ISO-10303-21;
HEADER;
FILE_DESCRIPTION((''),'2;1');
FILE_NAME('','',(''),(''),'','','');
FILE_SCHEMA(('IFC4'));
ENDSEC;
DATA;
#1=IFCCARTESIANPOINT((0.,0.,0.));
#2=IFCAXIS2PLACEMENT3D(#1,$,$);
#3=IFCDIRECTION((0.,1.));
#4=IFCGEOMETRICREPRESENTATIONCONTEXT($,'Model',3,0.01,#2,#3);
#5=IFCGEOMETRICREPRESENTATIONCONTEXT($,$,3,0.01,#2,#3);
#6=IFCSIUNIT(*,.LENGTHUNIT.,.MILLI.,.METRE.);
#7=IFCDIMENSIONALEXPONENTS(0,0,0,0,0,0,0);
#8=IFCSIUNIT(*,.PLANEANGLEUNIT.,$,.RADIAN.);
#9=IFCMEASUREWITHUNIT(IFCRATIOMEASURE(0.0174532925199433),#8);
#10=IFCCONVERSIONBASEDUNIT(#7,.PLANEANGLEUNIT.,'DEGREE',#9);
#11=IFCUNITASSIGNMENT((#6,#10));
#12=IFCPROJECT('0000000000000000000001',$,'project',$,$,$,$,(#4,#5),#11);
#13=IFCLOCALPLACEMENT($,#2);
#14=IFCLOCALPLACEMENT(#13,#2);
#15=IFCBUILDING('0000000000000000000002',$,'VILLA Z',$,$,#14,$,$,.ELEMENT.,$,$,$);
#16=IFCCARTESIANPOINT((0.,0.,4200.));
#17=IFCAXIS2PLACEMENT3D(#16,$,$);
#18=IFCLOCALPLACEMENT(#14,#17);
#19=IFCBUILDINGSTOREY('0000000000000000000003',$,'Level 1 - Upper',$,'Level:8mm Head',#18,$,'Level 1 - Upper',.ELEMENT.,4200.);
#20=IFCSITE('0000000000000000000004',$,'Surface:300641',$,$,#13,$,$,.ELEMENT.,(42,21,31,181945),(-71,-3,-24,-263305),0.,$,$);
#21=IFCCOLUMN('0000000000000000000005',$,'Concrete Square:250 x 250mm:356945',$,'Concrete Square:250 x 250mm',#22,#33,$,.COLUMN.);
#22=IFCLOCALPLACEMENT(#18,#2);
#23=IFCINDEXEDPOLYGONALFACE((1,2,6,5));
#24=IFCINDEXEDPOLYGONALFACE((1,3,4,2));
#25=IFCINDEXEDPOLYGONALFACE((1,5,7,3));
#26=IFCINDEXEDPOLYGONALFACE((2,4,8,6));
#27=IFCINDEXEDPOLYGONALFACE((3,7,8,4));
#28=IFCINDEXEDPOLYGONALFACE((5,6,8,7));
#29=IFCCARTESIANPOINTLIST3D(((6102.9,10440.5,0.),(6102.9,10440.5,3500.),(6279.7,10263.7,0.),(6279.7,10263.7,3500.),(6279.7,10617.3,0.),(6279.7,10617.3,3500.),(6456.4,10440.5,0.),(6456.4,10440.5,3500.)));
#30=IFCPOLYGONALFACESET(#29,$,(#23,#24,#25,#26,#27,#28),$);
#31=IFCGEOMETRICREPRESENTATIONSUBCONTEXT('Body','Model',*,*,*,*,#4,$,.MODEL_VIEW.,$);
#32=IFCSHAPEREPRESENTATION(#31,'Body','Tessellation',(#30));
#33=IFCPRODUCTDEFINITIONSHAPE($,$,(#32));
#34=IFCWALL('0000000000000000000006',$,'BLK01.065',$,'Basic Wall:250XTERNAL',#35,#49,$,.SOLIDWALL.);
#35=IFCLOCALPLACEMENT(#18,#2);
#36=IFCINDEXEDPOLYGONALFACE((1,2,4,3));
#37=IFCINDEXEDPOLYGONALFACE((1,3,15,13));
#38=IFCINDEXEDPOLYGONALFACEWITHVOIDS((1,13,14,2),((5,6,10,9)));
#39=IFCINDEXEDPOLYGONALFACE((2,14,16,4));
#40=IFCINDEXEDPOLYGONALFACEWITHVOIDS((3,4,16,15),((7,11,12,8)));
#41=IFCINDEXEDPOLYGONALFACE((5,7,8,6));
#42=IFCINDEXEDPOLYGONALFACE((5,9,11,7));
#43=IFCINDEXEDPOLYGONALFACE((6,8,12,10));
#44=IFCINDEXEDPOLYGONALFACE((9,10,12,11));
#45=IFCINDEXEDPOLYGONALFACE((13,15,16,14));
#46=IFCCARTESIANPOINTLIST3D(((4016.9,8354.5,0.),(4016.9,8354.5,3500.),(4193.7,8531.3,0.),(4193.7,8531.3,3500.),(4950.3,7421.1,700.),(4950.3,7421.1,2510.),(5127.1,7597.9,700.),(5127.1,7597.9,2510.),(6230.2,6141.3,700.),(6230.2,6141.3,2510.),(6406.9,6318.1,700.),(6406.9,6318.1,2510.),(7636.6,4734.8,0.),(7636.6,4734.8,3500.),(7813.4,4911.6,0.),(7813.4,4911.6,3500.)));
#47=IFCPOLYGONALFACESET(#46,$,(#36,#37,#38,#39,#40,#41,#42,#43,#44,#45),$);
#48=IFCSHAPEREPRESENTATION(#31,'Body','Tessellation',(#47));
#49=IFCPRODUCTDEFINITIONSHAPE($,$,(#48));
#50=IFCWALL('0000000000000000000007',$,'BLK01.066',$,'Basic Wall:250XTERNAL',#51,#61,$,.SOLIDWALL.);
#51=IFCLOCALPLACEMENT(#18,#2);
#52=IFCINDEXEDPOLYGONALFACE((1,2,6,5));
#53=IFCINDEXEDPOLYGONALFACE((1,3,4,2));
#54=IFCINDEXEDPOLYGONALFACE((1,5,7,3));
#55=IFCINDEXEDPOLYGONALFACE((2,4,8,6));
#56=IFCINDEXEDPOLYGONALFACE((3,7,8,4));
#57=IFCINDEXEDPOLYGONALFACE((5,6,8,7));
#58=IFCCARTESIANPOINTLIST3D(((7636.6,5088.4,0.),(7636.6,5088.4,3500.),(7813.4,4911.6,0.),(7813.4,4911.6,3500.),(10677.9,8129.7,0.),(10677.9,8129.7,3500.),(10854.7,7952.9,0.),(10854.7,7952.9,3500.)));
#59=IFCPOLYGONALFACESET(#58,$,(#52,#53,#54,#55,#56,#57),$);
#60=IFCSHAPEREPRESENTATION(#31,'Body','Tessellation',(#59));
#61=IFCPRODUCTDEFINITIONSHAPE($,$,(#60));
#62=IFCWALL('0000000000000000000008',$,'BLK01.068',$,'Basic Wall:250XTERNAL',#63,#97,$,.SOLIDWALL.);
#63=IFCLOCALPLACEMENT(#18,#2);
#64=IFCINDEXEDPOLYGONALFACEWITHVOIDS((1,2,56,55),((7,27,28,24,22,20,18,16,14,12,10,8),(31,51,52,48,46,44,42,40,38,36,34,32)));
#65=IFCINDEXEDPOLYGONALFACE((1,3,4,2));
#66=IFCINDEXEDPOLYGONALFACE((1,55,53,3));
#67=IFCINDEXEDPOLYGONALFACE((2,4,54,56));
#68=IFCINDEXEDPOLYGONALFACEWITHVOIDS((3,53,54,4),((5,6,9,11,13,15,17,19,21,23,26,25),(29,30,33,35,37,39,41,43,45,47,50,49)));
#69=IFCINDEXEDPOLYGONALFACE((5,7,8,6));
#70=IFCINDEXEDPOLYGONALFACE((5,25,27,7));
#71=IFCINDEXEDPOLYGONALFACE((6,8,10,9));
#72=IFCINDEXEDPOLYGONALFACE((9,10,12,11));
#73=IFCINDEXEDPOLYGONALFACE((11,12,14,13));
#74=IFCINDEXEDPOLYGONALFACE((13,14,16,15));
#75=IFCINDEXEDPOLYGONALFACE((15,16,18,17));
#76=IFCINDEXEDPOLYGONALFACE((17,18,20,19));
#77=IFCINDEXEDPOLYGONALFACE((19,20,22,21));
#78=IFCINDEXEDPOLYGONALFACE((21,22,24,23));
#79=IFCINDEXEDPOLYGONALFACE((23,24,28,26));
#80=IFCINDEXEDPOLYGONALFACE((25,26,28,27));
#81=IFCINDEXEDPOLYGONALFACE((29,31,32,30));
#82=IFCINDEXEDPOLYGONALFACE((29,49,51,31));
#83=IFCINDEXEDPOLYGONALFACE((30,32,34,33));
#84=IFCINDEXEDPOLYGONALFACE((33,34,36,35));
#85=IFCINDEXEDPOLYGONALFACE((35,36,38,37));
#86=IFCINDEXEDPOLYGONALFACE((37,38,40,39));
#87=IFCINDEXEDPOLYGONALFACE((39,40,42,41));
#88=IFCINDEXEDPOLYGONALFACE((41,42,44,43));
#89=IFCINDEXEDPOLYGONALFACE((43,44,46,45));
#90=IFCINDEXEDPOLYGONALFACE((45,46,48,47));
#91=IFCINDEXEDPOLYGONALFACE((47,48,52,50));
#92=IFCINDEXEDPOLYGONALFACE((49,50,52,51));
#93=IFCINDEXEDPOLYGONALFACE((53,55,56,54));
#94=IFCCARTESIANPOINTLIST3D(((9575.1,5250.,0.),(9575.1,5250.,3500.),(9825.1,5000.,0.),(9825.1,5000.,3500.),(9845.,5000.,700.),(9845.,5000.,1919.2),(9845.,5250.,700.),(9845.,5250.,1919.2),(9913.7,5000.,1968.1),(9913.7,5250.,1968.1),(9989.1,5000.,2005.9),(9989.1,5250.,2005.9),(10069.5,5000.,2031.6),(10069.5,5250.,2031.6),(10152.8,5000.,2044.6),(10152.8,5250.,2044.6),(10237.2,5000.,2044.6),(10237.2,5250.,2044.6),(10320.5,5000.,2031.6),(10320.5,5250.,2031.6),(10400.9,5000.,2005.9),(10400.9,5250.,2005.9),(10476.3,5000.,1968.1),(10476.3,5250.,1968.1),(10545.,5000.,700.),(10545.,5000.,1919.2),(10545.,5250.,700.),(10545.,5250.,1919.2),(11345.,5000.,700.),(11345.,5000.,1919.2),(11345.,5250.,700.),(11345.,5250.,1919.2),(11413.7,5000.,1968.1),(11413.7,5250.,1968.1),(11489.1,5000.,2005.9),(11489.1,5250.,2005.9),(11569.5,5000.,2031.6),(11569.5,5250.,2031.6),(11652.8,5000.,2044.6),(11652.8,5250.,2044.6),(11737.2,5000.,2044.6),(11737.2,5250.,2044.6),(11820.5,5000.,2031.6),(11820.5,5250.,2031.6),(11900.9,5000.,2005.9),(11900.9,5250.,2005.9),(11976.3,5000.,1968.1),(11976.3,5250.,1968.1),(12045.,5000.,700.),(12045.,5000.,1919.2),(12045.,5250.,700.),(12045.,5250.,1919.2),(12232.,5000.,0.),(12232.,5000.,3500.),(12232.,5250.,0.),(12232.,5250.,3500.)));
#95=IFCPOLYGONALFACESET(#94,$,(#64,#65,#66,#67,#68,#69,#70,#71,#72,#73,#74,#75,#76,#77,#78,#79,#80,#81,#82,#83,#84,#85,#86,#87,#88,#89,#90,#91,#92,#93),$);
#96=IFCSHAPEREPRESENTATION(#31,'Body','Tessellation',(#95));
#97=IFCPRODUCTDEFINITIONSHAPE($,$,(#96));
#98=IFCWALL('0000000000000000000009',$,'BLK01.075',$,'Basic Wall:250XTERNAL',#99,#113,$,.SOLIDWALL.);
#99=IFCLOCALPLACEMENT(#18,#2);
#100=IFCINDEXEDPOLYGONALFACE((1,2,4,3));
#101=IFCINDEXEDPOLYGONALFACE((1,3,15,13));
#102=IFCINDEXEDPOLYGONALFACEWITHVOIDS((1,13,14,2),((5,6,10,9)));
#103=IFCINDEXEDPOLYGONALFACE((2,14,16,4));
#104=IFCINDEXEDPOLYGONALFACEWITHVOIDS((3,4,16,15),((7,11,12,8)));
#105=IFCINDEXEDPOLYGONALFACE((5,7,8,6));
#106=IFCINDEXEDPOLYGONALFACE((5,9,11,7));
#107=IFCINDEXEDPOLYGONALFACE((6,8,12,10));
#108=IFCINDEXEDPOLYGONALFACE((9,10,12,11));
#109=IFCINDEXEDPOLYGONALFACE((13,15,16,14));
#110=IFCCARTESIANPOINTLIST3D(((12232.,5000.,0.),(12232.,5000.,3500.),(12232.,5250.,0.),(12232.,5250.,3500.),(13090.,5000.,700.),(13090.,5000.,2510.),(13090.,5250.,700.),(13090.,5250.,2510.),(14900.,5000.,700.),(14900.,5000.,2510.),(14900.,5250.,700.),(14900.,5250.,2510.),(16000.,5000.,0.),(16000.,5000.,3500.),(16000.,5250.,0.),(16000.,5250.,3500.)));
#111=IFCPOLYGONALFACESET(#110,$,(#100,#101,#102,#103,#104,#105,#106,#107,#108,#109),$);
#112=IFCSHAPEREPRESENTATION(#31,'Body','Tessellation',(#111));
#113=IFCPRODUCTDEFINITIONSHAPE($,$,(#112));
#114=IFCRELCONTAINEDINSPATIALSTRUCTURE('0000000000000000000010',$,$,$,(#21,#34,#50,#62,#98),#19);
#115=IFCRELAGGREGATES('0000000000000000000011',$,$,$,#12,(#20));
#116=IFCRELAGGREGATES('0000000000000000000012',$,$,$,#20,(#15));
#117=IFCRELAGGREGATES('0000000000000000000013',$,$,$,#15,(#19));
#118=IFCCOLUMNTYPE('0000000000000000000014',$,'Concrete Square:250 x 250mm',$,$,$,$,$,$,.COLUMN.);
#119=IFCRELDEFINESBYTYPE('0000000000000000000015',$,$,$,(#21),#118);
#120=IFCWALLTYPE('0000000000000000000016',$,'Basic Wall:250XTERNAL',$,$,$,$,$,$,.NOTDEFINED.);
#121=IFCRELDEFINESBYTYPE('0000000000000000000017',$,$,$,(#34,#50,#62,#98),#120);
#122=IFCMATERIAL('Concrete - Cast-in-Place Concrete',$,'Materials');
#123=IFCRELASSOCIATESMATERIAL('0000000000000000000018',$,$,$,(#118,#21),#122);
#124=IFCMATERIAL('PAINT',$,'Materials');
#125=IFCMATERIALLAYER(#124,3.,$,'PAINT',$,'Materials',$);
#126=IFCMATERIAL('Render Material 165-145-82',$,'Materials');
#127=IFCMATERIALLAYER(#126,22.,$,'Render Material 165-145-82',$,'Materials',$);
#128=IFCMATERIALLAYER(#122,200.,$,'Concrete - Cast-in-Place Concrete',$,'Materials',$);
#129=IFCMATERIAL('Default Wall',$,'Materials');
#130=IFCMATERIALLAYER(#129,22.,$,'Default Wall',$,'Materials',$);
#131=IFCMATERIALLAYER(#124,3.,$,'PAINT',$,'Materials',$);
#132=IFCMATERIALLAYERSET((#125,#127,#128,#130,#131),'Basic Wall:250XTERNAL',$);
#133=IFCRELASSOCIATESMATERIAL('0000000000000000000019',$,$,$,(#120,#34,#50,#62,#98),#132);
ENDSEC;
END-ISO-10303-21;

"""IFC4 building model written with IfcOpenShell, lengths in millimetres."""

from ifc_helpers import new_model, entity, si_unit, converted_unit, direction, frame, frame_2d, origin, origin_2d_with_axis, place, context, subcontext, project, spatial, polyline, circle_curve, parameter, trimmed, segment, composite_curve, rectangle, outline, extrude, clip, halfspace, source, transform, mapped, material, layer, layer_set, layer_usage, material_profile, profile_set, profile_usage, type_object, type_shapes, element, save


model = new_model("IFC4")

# Units and contexts
model_context = context("Model", 3, precision=0.01, world=origin(), true_north=direction((0.0, 1.0)))
context_of_model = context(None, 3, precision=0.01, world=origin(), true_north=direction((0.0, 1.0)))
body_context = subcontext(model_context, "Body", "Model", "MODEL_VIEW")
ifc_project = project(units=[si_unit("LENGTHUNIT", "METRE", prefix="MILLI"), converted_unit("PLANEANGLEUNIT", "DEGREE", entity("IfcRatioMeasure", 0.0174532925199433), si_unit("PLANEANGLEUNIT", "RADIAN"), dimensions=[0, 0, 0, 0, 0, 0, 0])], contexts=[model_context, context_of_model])

# Site, building, storey
site_placement = place(None, origin())
site = spatial("IfcSite", under=ifc_project, at=site_placement, Name="Surface:300641", CompositionType="ELEMENT", RefLatitude=(42, 21, 31, 181945), RefLongitude=(-71, -3, -24, -263305), RefElevation=0.0)
building_placement = place(site_placement, origin())
building = spatial("IfcBuilding", under=site, at=building_placement, Name="VILLA Z", CompositionType="ELEMENT")
storey_placement = place(building_placement, frame((0.0, 0.0, 4200.0)))
storey = spatial("IfcBuildingStorey", under=building, at=storey_placement, Name="Level 1 - Upper", ObjectType="Level:8mm Head", LongName="Level 1 - Upper", CompositionType="ELEMENT", Elevation=4200.0)

# Column
ifc_material_1 = material(Name="Concrete - Cast-in-Place Concrete", Category="Materials")
ifc_material_profile_1 = material_profile(ifc_material_1, rectangle(XDim=250.0, YDim=250.0, at=frame_2d((0.0, 0.0), x_axis=(1.0, 0.0))), Name="250 x 250mm")
ifc_profile_set_1 = profile_set([ifc_material_profile_1], Name="250 x 250mm")
ifc_profile_usage_1 = profile_usage(ifc_profile_set_1)
column_type = type_object("IfcColumnType", Name="Concrete Square:250 x 250mm", PredefinedType="COLUMN", material=ifc_profile_set_1)
shared_shape_1 = source(origin(), body_context, "Body", "SweptSolid", [
    extrude(rectangle(XDim=250.0, YDim=250.0, at=origin_2d_with_axis()), frame((6279.7, 10440.5, 4200.0), z_axis=(0.0, 0.0, 1.0), x_axis=(-0.707107, 0.707107, 0.0)), (0.0, 0.0, 1.0), 3500.0),
])
type_shapes(column_type, [shared_shape_1])
column_placement = place(storey_placement, frame((0.0, 0.0, -4200.0)))
element("IfcColumn", 1, at=column_placement, inside=storey, type_object=column_type, material=ifc_profile_usage_1, Name="Concrete Square:250 x 250mm:356945", ObjectType="Concrete Square:250 x 250mm", PredefinedType="COLUMN", context=body_context, shape_type="MappedRepresentation", body=[
    mapped(shared_shape_1, transform((0.0, 0.0, 0.0), scale=1.0)),
])

# Wall, opening
ifc_material_2 = material(Name="PAINT", Category="Materials")
ifc_layer_1 = layer(ifc_material_2, 3.0, Name="PAINT", Category="Materials")
ifc_material_3 = material(Name="Render Material 165-145-82", Category="Materials")
ifc_layer_2 = layer(ifc_material_3, 22.0, Name="Render Material 165-145-82", Category="Materials")
ifc_layer_3 = layer(ifc_material_1, 200.0, Name="Concrete - Cast-in-Place Concrete", Category="Materials")
ifc_material_4 = material(Name="Default Wall", Category="Materials")
ifc_layer_4 = layer(ifc_material_4, 22.0, Name="Default Wall", Category="Materials")
ifc_layer_5 = layer(ifc_material_2, 3.0, Name="PAINT", Category="Materials")
ifc_layer_set_1 = layer_set([ifc_layer_1, ifc_layer_2, ifc_layer_3, ifc_layer_4, ifc_layer_5], Name="Basic Wall:250XTERNAL")
ifc_layer_usage_1 = layer_usage(ifc_layer_set_1, "AXIS2", "NEGATIVE", 125.0)
wall_type_1 = type_object("IfcWallType", Name="Basic Wall:250XTERNAL", PredefinedType="NOTDEFINED", material=ifc_layer_set_1)
wall_1_placement = place(storey_placement, frame((7725.0, 4823.2, 0.0), z_axis=(0.0, 0.0, 1.0), x_axis=(-0.707107, 0.707107, 0.0)))
wall_1 = element("IfcWall", 2, at=wall_1_placement, inside=storey, type_object=wall_type_1, material=ifc_layer_usage_1, Name="BLK01.065", ObjectType="Basic Wall:250XTERNAL", PredefinedType="SOLIDWALL", context=body_context, shape_type="Clipping", body=[
    clip(extrude(rectangle(XDim=5119.0, YDim=250.0, at=frame_2d((2559.5, 0.0), x_axis=(-1.0, 0.0))), origin(), (0.0, 0.0, 1.0), 3500.0), halfspace(origin(), True)),
])
opening_1_placement = place(wall_1_placement, frame((1989.0, -125.0, 700.0)))
element("IfcOpeningElement", 3, at=opening_1_placement, cuts=wall_1, ObjectType="Opening", PredefinedType="OPENING", context=body_context, shape_type="SweptSolid", body=[
    extrude(rectangle(XDim=1810.0, YDim=1810.0, at=frame_2d((905.0, 905.0), x_axis=(-1.0, 0.0))), frame((0.0, 0.0, 0.0), z_axis=(0.0, 1.0, 0.0), x_axis=(0.0, 0.0, 1.0)), (0.0, 0.0, 1.0), 250.0),
])

# Wall
ifc_layer_usage_2 = layer_usage(ifc_layer_set_1, "AXIS2", "NEGATIVE", 125.0)
wall_2_placement = place(storey_placement, frame((7725.0, 5000.0, 0.0), z_axis=(0.0, 0.0, 1.0), x_axis=(0.707107, 0.707107, 0.0)))
element("IfcWall", 4, at=wall_2_placement, inside=storey, type_object=wall_type_1, material=ifc_layer_usage_2, Name="BLK01.066", ObjectType="Basic Wall:250XTERNAL", PredefinedType="SOLIDWALL", context=body_context, shape_type="Clipping", body=[
    clip(extrude(rectangle(XDim=4301.0, YDim=250.0, at=frame_2d((2150.5, 0.0), x_axis=(-1.0, 0.0))), origin(), (0.0, 0.0, 1.0), 3500.0), halfspace(origin(), True)),
])

# Wall, openings
ifc_layer_usage_3 = layer_usage(ifc_layer_set_1, "AXIS2", "NEGATIVE", 125.0)
wall_3_placement = place(storey_placement, frame((9575.1, 5125.0, 0.0)))
wall_3 = element("IfcWall", 5, at=wall_3_placement, inside=storey, type_object=wall_type_1, material=ifc_layer_usage_3, Name="BLK01.068", ObjectType="Basic Wall:250XTERNAL", PredefinedType="SOLIDWALL", context=body_context, shape_type="Clipping", body=[
    clip(extrude(outline(polyline([(2656.9, -125.0), (2656.9, 125.0), (0.0, 125.0), (250.0, -125.0), (2656.9, -125.0)])), origin(), (0.0, 0.0, 1.0), 3500.0), halfspace(origin(), True)),
])
opening_2_placement = place(wall_3_placement, frame((969.9, 125.0, 700.0)))
element("IfcOpeningElement", 6, at=opening_2_placement, cuts=wall_3, ObjectType="Opening", PredefinedType="OPENING", context=body_context, shape_type="SweptSolid", body=[
    extrude(outline(composite_curve([segment(polyline([(0.0, 0.0), (1219.2, 0.0)]), True, "CONTINUOUS"), segment(trimmed(circle_curve(frame_2d((800.4, 350.0), x_axis=(0.0, 1.0)), 545.8), [parameter(230.112671)], [parameter(309.887329)], True, "PARAMETER"), True, "CONTINUOUS"), segment(polyline([(1219.2, 700.0), (0.0, 700.0)]), True, "CONTINUOUS"), segment(polyline([(0.0, 700.0), (0.0, 0.0)]), True, "CONTINUOUS")], self_intersect=False)), frame((0.0, 0.0, 0.0), z_axis=(0.0, -1.0, 0.0), x_axis=(0.0, 0.0, 1.0)), (0.0, 0.0, 1.0), 250.0),
])
opening_3_placement = place(wall_3_placement, frame((2469.9, 125.0, 700.0)))
element("IfcOpeningElement", 7, at=opening_3_placement, cuts=wall_3, ObjectType="Opening", PredefinedType="OPENING", context=body_context, shape_type="SweptSolid", body=[
    extrude(outline(composite_curve([segment(polyline([(0.0, 0.0), (1219.2, 0.0)]), True, "CONTINUOUS"), segment(trimmed(circle_curve(frame_2d((800.4, 350.0), x_axis=(0.0, 1.0)), 545.8), [parameter(230.112671)], [parameter(309.887329)], True, "PARAMETER"), True, "CONTINUOUS"), segment(polyline([(1219.2, 700.0), (0.0, 700.0)]), True, "CONTINUOUS"), segment(polyline([(0.0, 700.0), (0.0, 0.0)]), True, "CONTINUOUS")], self_intersect=False)), frame((0.0, 0.0, 0.0), z_axis=(0.0, -1.0, 0.0), x_axis=(0.0, 0.0, 1.0)), (0.0, 0.0, 1.0), 250.0),
])

# Wall, opening
ifc_layer_usage_4 = layer_usage(ifc_layer_set_1, "AXIS2", "NEGATIVE", 125.0)
wall_4_placement = place(storey_placement, frame((12232.0, 5125.0, 0.0)))
wall_4 = element("IfcWall", 8, at=wall_4_placement, inside=storey, type_object=wall_type_1, material=ifc_layer_usage_4, Name="BLK01.075", ObjectType="Basic Wall:250XTERNAL", PredefinedType="SOLIDWALL", context=body_context, shape_type="Clipping", body=[
    clip(extrude(rectangle(XDim=3768.0, YDim=250.0, at=frame_2d((1884.0, 0.0), x_axis=(-1.0, 0.0))), origin(), (0.0, 0.0, 1.0), 3500.0), halfspace(origin(), True)),
])
opening_4_placement = place(wall_4_placement, frame((2668.0, 125.0, 700.0)))
element("IfcOpeningElement", 9, at=opening_4_placement, cuts=wall_4, ObjectType="Opening", PredefinedType="OPENING", context=body_context, shape_type="SweptSolid", body=[
    extrude(rectangle(XDim=1810.0, YDim=1810.0, at=frame_2d((905.0, 905.0), x_axis=(-1.0, 0.0))), frame((0.0, 0.0, 0.0), z_axis=(0.0, -1.0, 0.0), x_axis=(0.0, 0.0, 1.0)), (0.0, 0.0, 1.0), 250.0),
])

save(model, "model.ifc")
